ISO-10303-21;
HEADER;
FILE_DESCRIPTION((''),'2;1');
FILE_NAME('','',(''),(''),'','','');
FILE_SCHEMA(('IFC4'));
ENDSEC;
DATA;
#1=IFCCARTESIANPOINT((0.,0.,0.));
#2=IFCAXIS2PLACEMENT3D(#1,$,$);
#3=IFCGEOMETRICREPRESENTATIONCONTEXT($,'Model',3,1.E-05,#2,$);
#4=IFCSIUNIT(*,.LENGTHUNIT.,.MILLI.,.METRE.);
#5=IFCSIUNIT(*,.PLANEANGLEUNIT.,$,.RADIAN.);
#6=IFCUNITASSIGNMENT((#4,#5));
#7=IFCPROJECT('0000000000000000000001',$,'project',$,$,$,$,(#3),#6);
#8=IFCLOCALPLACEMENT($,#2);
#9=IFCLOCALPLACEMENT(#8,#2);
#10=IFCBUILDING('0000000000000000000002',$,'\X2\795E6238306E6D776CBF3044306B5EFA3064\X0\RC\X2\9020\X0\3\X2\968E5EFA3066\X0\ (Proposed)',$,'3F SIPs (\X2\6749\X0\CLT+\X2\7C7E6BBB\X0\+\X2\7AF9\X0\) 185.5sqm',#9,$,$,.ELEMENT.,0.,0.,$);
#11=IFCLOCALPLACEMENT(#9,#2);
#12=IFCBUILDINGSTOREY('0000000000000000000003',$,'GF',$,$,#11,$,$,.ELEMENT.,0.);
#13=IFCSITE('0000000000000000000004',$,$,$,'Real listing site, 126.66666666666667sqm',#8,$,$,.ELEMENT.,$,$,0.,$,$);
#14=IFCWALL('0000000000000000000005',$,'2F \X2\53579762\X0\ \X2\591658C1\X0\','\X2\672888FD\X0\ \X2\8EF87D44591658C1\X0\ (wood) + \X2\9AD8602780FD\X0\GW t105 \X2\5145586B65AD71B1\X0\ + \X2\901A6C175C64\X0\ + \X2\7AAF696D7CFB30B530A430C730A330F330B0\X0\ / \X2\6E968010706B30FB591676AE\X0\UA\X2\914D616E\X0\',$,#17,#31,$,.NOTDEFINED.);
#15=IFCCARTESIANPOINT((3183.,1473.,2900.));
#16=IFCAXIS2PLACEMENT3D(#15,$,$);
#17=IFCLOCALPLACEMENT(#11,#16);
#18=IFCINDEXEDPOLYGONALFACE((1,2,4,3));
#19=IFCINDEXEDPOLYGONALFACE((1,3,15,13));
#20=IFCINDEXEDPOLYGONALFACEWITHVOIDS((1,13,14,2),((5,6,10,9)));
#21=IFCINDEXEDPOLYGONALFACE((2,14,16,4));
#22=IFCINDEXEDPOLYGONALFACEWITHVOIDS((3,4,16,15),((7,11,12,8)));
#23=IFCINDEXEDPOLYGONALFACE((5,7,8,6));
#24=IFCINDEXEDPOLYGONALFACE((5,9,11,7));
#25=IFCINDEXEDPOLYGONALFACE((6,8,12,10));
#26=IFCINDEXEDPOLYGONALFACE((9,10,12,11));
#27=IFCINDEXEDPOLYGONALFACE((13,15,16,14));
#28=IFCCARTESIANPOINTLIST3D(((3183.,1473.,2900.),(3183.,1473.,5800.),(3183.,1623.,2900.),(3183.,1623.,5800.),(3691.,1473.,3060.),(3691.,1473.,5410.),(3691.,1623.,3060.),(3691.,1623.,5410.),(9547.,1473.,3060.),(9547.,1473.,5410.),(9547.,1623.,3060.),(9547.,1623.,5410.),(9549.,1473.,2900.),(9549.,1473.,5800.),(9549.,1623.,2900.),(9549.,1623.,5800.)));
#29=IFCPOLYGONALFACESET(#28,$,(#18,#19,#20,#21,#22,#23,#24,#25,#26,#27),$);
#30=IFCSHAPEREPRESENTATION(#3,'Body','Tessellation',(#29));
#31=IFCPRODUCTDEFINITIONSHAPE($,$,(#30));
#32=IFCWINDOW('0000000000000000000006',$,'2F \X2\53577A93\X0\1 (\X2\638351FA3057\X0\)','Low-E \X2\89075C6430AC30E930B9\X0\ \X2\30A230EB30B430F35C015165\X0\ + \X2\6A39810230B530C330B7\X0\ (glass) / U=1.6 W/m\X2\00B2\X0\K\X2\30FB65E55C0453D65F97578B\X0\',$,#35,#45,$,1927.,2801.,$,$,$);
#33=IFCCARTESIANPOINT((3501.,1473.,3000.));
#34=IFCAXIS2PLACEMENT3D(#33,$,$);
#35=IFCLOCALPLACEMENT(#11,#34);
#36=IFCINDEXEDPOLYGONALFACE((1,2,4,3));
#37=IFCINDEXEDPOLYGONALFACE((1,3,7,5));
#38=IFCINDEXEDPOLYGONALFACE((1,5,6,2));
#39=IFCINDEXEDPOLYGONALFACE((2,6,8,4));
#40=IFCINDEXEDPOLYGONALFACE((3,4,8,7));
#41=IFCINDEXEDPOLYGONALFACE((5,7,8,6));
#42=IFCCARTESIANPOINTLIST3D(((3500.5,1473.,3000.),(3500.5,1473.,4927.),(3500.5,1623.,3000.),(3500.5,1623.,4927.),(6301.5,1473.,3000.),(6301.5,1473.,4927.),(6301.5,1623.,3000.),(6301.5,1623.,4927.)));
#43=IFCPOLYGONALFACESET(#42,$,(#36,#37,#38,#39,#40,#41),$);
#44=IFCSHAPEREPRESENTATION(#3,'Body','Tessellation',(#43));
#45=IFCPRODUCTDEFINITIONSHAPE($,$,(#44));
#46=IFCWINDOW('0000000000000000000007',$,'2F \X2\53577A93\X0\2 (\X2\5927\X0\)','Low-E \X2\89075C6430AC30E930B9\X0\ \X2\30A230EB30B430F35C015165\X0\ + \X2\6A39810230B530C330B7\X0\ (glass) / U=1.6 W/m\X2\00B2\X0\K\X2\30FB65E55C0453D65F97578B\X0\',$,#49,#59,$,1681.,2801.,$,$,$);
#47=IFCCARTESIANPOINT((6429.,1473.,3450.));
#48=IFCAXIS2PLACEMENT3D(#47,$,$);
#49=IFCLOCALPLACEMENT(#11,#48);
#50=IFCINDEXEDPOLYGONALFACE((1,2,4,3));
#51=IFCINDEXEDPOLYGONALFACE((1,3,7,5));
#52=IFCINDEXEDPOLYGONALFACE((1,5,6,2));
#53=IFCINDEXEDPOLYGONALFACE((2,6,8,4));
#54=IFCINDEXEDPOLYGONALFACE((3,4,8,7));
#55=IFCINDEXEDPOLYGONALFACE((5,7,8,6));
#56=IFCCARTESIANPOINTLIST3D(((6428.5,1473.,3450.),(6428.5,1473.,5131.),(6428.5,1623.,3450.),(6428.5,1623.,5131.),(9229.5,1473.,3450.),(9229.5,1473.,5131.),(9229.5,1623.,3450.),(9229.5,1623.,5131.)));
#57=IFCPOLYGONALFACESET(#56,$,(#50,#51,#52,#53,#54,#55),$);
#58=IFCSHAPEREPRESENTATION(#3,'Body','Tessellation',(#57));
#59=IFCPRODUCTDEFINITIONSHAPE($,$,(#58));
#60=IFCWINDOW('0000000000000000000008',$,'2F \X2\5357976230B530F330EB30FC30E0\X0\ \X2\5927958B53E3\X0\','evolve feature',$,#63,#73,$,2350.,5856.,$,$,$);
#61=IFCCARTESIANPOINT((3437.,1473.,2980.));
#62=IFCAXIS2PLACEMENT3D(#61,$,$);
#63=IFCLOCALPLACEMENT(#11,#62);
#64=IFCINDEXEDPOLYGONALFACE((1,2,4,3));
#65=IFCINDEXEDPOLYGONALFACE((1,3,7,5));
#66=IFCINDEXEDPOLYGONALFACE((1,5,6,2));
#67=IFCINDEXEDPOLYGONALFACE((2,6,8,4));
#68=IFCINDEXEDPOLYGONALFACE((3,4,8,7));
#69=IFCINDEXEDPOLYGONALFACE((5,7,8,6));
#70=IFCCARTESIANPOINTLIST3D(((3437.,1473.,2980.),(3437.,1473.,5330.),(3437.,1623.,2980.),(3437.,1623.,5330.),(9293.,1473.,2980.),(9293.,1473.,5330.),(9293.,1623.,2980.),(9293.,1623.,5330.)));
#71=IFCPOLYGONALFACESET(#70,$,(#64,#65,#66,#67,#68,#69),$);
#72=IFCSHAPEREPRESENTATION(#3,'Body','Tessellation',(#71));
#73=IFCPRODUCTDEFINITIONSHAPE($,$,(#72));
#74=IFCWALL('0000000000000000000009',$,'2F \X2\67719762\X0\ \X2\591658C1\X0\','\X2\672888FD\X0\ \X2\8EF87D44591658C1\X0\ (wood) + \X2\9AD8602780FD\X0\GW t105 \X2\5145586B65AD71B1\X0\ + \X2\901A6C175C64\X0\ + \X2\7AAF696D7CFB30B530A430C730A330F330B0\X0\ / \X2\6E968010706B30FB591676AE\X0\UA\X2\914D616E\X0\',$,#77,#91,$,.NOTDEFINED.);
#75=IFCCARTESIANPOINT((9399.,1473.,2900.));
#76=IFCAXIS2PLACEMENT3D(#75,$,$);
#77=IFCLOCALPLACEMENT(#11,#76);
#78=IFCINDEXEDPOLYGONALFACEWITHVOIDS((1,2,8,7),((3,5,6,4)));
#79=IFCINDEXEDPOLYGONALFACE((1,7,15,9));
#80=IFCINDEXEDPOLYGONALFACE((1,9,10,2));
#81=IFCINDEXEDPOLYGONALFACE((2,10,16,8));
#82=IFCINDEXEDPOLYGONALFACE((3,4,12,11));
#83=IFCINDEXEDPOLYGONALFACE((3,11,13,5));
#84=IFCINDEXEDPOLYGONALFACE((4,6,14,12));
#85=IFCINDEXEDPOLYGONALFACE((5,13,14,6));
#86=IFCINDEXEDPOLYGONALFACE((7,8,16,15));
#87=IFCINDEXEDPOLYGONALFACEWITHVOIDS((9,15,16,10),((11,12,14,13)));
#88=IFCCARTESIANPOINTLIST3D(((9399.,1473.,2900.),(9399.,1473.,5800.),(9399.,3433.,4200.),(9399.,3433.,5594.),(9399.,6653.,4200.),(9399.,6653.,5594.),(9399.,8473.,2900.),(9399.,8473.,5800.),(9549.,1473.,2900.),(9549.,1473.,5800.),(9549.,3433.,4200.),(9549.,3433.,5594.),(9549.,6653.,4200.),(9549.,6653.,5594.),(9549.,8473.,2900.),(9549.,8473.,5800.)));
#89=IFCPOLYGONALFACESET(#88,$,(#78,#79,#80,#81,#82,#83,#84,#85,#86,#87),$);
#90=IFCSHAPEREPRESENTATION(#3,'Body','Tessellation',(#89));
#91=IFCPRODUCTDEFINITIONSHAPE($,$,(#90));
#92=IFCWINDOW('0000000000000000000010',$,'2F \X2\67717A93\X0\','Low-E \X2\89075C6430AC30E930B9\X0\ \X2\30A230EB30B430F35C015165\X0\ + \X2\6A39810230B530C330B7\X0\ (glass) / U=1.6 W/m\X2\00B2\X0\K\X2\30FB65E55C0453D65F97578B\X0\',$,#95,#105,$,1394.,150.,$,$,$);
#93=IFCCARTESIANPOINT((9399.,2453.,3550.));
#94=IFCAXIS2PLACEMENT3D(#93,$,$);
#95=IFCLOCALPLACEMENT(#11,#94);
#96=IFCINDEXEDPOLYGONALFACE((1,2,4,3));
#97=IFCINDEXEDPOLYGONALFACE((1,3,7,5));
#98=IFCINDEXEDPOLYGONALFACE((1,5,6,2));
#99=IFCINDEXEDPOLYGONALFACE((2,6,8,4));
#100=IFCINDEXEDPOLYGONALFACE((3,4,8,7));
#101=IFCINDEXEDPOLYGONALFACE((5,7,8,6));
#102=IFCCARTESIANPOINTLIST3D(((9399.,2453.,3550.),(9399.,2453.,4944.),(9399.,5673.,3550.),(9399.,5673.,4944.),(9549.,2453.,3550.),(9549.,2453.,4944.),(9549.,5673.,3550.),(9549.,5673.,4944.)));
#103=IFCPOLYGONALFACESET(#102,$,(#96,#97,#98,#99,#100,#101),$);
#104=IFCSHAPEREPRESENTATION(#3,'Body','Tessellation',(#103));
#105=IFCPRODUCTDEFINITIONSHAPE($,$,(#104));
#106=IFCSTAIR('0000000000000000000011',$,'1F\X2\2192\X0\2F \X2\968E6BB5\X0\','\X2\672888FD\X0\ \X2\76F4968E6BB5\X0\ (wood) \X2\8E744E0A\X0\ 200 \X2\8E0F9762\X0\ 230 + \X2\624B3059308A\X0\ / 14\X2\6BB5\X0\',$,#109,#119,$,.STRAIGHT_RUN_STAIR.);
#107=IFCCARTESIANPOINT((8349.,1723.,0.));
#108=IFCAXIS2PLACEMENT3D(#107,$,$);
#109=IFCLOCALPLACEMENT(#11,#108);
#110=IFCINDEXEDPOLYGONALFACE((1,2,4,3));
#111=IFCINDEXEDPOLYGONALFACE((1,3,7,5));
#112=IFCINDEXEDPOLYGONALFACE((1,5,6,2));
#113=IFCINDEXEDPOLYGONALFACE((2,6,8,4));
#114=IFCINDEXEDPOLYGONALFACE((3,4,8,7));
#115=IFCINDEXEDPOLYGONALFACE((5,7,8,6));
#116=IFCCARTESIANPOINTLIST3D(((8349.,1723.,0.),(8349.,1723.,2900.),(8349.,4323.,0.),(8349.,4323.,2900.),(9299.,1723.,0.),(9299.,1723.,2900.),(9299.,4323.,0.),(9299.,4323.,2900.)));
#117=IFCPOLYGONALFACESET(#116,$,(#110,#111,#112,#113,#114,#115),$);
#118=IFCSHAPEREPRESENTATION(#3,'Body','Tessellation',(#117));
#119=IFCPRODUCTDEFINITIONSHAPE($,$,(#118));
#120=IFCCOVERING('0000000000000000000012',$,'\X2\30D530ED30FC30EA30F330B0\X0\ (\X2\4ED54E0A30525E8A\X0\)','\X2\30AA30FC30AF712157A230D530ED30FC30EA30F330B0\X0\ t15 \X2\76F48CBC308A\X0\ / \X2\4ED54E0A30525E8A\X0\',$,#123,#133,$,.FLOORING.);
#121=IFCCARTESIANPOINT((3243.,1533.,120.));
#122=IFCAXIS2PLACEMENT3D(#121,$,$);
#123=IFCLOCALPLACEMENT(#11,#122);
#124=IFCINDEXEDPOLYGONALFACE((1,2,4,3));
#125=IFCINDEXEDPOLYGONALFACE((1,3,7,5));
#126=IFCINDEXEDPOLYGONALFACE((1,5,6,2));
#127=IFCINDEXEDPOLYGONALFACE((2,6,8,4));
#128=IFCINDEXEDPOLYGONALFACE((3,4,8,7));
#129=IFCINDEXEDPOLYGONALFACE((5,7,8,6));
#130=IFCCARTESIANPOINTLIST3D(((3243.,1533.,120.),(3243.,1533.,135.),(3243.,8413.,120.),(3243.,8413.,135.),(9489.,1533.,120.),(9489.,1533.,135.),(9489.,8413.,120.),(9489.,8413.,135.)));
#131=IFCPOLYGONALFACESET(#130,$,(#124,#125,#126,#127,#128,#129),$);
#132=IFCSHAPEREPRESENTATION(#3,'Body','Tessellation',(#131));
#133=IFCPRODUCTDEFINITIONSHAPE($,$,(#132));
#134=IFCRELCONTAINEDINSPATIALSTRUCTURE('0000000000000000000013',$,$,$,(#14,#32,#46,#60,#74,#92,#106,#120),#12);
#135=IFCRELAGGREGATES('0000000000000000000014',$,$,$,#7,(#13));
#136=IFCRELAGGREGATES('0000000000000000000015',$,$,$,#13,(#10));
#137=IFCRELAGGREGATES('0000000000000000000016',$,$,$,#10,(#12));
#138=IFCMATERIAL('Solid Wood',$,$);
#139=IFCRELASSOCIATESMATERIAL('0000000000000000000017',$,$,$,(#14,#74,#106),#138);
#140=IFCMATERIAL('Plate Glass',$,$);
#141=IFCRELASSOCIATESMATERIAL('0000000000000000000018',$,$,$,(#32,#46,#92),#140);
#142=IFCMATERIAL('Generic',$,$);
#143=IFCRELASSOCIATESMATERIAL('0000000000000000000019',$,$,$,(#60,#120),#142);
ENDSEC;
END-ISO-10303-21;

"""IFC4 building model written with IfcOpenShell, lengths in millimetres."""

from ifc_helpers import new_model, si_unit, frame, frame_2d, origin, place, context, project, spatial, rectangle, extrude, material, element, fill, save


model = new_model("IFC4")

# Units and contexts
model_context = context("Model", 3, precision=1e-05, world=origin())
ifc_project = project(units=[si_unit("LENGTHUNIT", "METRE", prefix="MILLI"), si_unit("PLANEANGLEUNIT", "RADIAN")], contexts=[model_context])

# Site, building, storey
site_placement = place(None, origin())
site = spatial("IfcSite", under=ifc_project, at=site_placement, ObjectType="Real listing site, 126.66666666666667sqm", CompositionType="ELEMENT", RefElevation=0.0)
building_placement = place(site_placement, origin())
building = spatial("IfcBuilding", under=site, at=building_placement, Name="神戸の海沿いに建つRC造3階建て (Proposed)", ObjectType="3F SIPs (杉CLT+籾殻+竹) 185.5sqm", CompositionType="ELEMENT", ElevationOfRefHeight=0.0, ElevationOfTerrain=0.0)
storey_placement = place(building_placement, origin())
storey = spatial("IfcBuildingStorey", under=building, at=storey_placement, Name="GF", CompositionType="ELEMENT", Elevation=0.0)

# Shared definitions
ifc_material_1 = material(Name="Solid Wood")

# Shared definitions
ifc_material_2 = material(Name="Plate Glass")
ifc_material_3 = material(Name="Generic")

# Wall, openings, windows
wall_1_placement = place(storey_placement, frame((3183.0, 1473.0, 2900.0)))
wall_1 = element("IfcWall", 1, at=wall_1_placement, inside=storey, material=ifc_material_1, Name="2F 南面 外壁", Description="木製 軸組外壁 (wood) + 高性能GW t105 充填断熱 + 通気層 + 窯業系サイディング / 準耐火・外皮UA配慮", PredefinedType="NOTDEFINED", context=model_context, shape_type="SweptSolid", body=[
    extrude(rectangle(XDim=6366.0, YDim=150.0, at=frame_2d((3183.0, 75.0))), frame((3183.0, 1473.0, 2900.0)), (0.0, 0.0, 1.0), 2900.0),
])
opening_1_placement = place(storey_placement, frame((3501.0, 1473.0, 3000.0)))
opening_1 = element("IfcOpeningElement", 2, at=opening_1_placement, cuts=wall_1, PredefinedType="NOTDEFINED", context=model_context, shape_type="SweptSolid", body=[
    extrude(rectangle(XDim=2801.0, YDim=150.0, at=frame_2d((1400.0, 75.0))), frame((3501.0, 1473.0, 3000.0)), (0.0, 0.0, 1.0), 1927.0),
])
opening_2_placement = place(storey_placement, frame((6429.0, 1473.0, 3450.0)))
opening_2 = element("IfcOpeningElement", 3, at=opening_2_placement, cuts=wall_1, PredefinedType="NOTDEFINED", context=model_context, shape_type="SweptSolid", body=[
    extrude(rectangle(XDim=2801.0, YDim=150.0, at=frame_2d((1400.0, 75.0))), frame((6429.0, 1473.0, 3450.0)), (0.0, 0.0, 1.0), 1681.0),
])
opening_3_placement = place(storey_placement, frame((3437.0, 1473.0, 2980.0)))
opening_3 = element("IfcOpeningElement", 4, at=opening_3_placement, cuts=wall_1, PredefinedType="NOTDEFINED", context=model_context, shape_type="SweptSolid", body=[
    extrude(rectangle(XDim=5856.0, YDim=150.0, at=frame_2d((2928.0, 75.0))), frame((3437.0, 1473.0, 2980.0)), (0.0, 0.0, 1.0), 2350.0),
])
window_1_placement = place(storey_placement, frame((3501.0, 1473.0, 3000.0)))
window_1 = element("IfcWindow", 5, at=window_1_placement, inside=storey, material=ifc_material_2, Name="2F 南窓1 (掃出し)", Description="Low-E 複層ガラス アルゴン封入 + 樹脂サッシ (glass) / U=1.6 W/m²K・日射取得型", OverallHeight=1927.0, OverallWidth=2801.0, context=model_context, shape_type="SweptSolid", body=[
    extrude(rectangle(XDim=2801.0, YDim=150.0, at=frame_2d((1400.0, 75.0))), frame((3501.0, 1473.0, 3000.0)), (0.0, 0.0, 1.0), 1927.0),
])
fill(opening_1, window_1)
window_2_placement = place(storey_placement, frame((6429.0, 1473.0, 3450.0)))
window_2 = element("IfcWindow", 6, at=window_2_placement, inside=storey, material=ifc_material_2, Name="2F 南窓2 (大)", Description="Low-E 複層ガラス アルゴン封入 + 樹脂サッシ (glass) / U=1.6 W/m²K・日射取得型", OverallHeight=1681.0, OverallWidth=2801.0, context=model_context, shape_type="SweptSolid", body=[
    extrude(rectangle(XDim=2801.0, YDim=150.0, at=frame_2d((1400.0, 75.0))), frame((6429.0, 1473.0, 3450.0)), (0.0, 0.0, 1.0), 1681.0),
])
fill(opening_2, window_2)
window_3_placement = place(storey_placement, frame((3437.0, 1473.0, 2980.0)))
window_3 = element("IfcWindow", 7, at=window_3_placement, inside=storey, material=ifc_material_3, Name="2F 南面サンルーム 大開口", Description="evolve feature", OverallHeight=2350.0, OverallWidth=5856.0, context=model_context, shape_type="SweptSolid", body=[
    extrude(rectangle(XDim=5856.0, YDim=150.0, at=frame_2d((2928.0, 75.0))), frame((3437.0, 1473.0, 2980.0)), (0.0, 0.0, 1.0), 2350.0),
])
fill(opening_3, window_3)

# Wall, opening, window
wall_2_placement = place(storey_placement, frame((9399.0, 1473.0, 2900.0)))
wall_2 = element("IfcWall", 8, at=wall_2_placement, inside=storey, material=ifc_material_1, Name="2F 東面 外壁", Description="木製 軸組外壁 (wood) + 高性能GW t105 充填断熱 + 通気層 + 窯業系サイディング / 準耐火・外皮UA配慮", PredefinedType="NOTDEFINED", context=model_context, shape_type="SweptSolid", body=[
    extrude(rectangle(XDim=150.0, YDim=7000.0, at=frame_2d((75.0, 3500.0))), frame((9399.0, 1473.0, 2900.0)), (0.0, 0.0, 1.0), 2900.0),
])
opening_4_placement = place(storey_placement, frame((9399.0, 2453.0, 3550.0)))
opening_4 = element("IfcOpeningElement", 9, at=opening_4_placement, cuts=wall_2, PredefinedType="NOTDEFINED", context=model_context, shape_type="SweptSolid", body=[
    extrude(rectangle(XDim=150.0, YDim=3220.0, at=frame_2d((75.0, 1610.0))), frame((9399.0, 2453.0, 3550.0)), (0.0, 0.0, 1.0), 1394.0),
])
window_4_placement = place(storey_placement, frame((9399.0, 2453.0, 3550.0)))
window_4 = element("IfcWindow", 10, at=window_4_placement, inside=storey, material=ifc_material_2, Name="2F 東窓", Description="Low-E 複層ガラス アルゴン封入 + 樹脂サッシ (glass) / U=1.6 W/m²K・日射取得型", OverallHeight=1394.0, OverallWidth=150.0, context=model_context, shape_type="SweptSolid", body=[
    extrude(rectangle(XDim=150.0, YDim=3220.0, at=frame_2d((75.0, 1610.0))), frame((9399.0, 2453.0, 3550.0)), (0.0, 0.0, 1.0), 1394.0),
])
fill(opening_4, window_4)

# Stair
stair_placement = place(storey_placement, frame((8349.0, 1723.0, 0.0)))
element("IfcStair", 11, at=stair_placement, inside=storey, material=ifc_material_1, Name="1F→2F 階段", Description="木製 直階段 (wood) 蹴上 200 踏面 230 + 手すり / 14段", PredefinedType="STRAIGHT_RUN_STAIR", context=model_context, shape_type="SweptSolid", body=[
    extrude(rectangle(XDim=950.0, YDim=2600.0, at=frame_2d((475.0, 1300.0))), frame((8349.0, 1723.0, 0.0)), (0.0, 0.0, 1.0), 2900.0),
])

# Covering
covering_placement = place(storey_placement, frame((3243.0, 1533.0, 120.0)))
element("IfcCovering", 12, at=covering_placement, inside=storey, material=ifc_material_3, Name="フローリング (仕上げ床)", Description="オーク無垢フローリング t15 直貼り / 仕上げ床", PredefinedType="FLOORING", context=model_context, shape_type="SweptSolid", body=[
    extrude(rectangle(XDim=6246.0, YDim=6880.0, at=frame_2d((3123.0, 3440.0))), frame((3243.0, 1533.0, 120.0)), (0.0, 0.0, 1.0), 15.0),
])

save(model, "model.ifc")
